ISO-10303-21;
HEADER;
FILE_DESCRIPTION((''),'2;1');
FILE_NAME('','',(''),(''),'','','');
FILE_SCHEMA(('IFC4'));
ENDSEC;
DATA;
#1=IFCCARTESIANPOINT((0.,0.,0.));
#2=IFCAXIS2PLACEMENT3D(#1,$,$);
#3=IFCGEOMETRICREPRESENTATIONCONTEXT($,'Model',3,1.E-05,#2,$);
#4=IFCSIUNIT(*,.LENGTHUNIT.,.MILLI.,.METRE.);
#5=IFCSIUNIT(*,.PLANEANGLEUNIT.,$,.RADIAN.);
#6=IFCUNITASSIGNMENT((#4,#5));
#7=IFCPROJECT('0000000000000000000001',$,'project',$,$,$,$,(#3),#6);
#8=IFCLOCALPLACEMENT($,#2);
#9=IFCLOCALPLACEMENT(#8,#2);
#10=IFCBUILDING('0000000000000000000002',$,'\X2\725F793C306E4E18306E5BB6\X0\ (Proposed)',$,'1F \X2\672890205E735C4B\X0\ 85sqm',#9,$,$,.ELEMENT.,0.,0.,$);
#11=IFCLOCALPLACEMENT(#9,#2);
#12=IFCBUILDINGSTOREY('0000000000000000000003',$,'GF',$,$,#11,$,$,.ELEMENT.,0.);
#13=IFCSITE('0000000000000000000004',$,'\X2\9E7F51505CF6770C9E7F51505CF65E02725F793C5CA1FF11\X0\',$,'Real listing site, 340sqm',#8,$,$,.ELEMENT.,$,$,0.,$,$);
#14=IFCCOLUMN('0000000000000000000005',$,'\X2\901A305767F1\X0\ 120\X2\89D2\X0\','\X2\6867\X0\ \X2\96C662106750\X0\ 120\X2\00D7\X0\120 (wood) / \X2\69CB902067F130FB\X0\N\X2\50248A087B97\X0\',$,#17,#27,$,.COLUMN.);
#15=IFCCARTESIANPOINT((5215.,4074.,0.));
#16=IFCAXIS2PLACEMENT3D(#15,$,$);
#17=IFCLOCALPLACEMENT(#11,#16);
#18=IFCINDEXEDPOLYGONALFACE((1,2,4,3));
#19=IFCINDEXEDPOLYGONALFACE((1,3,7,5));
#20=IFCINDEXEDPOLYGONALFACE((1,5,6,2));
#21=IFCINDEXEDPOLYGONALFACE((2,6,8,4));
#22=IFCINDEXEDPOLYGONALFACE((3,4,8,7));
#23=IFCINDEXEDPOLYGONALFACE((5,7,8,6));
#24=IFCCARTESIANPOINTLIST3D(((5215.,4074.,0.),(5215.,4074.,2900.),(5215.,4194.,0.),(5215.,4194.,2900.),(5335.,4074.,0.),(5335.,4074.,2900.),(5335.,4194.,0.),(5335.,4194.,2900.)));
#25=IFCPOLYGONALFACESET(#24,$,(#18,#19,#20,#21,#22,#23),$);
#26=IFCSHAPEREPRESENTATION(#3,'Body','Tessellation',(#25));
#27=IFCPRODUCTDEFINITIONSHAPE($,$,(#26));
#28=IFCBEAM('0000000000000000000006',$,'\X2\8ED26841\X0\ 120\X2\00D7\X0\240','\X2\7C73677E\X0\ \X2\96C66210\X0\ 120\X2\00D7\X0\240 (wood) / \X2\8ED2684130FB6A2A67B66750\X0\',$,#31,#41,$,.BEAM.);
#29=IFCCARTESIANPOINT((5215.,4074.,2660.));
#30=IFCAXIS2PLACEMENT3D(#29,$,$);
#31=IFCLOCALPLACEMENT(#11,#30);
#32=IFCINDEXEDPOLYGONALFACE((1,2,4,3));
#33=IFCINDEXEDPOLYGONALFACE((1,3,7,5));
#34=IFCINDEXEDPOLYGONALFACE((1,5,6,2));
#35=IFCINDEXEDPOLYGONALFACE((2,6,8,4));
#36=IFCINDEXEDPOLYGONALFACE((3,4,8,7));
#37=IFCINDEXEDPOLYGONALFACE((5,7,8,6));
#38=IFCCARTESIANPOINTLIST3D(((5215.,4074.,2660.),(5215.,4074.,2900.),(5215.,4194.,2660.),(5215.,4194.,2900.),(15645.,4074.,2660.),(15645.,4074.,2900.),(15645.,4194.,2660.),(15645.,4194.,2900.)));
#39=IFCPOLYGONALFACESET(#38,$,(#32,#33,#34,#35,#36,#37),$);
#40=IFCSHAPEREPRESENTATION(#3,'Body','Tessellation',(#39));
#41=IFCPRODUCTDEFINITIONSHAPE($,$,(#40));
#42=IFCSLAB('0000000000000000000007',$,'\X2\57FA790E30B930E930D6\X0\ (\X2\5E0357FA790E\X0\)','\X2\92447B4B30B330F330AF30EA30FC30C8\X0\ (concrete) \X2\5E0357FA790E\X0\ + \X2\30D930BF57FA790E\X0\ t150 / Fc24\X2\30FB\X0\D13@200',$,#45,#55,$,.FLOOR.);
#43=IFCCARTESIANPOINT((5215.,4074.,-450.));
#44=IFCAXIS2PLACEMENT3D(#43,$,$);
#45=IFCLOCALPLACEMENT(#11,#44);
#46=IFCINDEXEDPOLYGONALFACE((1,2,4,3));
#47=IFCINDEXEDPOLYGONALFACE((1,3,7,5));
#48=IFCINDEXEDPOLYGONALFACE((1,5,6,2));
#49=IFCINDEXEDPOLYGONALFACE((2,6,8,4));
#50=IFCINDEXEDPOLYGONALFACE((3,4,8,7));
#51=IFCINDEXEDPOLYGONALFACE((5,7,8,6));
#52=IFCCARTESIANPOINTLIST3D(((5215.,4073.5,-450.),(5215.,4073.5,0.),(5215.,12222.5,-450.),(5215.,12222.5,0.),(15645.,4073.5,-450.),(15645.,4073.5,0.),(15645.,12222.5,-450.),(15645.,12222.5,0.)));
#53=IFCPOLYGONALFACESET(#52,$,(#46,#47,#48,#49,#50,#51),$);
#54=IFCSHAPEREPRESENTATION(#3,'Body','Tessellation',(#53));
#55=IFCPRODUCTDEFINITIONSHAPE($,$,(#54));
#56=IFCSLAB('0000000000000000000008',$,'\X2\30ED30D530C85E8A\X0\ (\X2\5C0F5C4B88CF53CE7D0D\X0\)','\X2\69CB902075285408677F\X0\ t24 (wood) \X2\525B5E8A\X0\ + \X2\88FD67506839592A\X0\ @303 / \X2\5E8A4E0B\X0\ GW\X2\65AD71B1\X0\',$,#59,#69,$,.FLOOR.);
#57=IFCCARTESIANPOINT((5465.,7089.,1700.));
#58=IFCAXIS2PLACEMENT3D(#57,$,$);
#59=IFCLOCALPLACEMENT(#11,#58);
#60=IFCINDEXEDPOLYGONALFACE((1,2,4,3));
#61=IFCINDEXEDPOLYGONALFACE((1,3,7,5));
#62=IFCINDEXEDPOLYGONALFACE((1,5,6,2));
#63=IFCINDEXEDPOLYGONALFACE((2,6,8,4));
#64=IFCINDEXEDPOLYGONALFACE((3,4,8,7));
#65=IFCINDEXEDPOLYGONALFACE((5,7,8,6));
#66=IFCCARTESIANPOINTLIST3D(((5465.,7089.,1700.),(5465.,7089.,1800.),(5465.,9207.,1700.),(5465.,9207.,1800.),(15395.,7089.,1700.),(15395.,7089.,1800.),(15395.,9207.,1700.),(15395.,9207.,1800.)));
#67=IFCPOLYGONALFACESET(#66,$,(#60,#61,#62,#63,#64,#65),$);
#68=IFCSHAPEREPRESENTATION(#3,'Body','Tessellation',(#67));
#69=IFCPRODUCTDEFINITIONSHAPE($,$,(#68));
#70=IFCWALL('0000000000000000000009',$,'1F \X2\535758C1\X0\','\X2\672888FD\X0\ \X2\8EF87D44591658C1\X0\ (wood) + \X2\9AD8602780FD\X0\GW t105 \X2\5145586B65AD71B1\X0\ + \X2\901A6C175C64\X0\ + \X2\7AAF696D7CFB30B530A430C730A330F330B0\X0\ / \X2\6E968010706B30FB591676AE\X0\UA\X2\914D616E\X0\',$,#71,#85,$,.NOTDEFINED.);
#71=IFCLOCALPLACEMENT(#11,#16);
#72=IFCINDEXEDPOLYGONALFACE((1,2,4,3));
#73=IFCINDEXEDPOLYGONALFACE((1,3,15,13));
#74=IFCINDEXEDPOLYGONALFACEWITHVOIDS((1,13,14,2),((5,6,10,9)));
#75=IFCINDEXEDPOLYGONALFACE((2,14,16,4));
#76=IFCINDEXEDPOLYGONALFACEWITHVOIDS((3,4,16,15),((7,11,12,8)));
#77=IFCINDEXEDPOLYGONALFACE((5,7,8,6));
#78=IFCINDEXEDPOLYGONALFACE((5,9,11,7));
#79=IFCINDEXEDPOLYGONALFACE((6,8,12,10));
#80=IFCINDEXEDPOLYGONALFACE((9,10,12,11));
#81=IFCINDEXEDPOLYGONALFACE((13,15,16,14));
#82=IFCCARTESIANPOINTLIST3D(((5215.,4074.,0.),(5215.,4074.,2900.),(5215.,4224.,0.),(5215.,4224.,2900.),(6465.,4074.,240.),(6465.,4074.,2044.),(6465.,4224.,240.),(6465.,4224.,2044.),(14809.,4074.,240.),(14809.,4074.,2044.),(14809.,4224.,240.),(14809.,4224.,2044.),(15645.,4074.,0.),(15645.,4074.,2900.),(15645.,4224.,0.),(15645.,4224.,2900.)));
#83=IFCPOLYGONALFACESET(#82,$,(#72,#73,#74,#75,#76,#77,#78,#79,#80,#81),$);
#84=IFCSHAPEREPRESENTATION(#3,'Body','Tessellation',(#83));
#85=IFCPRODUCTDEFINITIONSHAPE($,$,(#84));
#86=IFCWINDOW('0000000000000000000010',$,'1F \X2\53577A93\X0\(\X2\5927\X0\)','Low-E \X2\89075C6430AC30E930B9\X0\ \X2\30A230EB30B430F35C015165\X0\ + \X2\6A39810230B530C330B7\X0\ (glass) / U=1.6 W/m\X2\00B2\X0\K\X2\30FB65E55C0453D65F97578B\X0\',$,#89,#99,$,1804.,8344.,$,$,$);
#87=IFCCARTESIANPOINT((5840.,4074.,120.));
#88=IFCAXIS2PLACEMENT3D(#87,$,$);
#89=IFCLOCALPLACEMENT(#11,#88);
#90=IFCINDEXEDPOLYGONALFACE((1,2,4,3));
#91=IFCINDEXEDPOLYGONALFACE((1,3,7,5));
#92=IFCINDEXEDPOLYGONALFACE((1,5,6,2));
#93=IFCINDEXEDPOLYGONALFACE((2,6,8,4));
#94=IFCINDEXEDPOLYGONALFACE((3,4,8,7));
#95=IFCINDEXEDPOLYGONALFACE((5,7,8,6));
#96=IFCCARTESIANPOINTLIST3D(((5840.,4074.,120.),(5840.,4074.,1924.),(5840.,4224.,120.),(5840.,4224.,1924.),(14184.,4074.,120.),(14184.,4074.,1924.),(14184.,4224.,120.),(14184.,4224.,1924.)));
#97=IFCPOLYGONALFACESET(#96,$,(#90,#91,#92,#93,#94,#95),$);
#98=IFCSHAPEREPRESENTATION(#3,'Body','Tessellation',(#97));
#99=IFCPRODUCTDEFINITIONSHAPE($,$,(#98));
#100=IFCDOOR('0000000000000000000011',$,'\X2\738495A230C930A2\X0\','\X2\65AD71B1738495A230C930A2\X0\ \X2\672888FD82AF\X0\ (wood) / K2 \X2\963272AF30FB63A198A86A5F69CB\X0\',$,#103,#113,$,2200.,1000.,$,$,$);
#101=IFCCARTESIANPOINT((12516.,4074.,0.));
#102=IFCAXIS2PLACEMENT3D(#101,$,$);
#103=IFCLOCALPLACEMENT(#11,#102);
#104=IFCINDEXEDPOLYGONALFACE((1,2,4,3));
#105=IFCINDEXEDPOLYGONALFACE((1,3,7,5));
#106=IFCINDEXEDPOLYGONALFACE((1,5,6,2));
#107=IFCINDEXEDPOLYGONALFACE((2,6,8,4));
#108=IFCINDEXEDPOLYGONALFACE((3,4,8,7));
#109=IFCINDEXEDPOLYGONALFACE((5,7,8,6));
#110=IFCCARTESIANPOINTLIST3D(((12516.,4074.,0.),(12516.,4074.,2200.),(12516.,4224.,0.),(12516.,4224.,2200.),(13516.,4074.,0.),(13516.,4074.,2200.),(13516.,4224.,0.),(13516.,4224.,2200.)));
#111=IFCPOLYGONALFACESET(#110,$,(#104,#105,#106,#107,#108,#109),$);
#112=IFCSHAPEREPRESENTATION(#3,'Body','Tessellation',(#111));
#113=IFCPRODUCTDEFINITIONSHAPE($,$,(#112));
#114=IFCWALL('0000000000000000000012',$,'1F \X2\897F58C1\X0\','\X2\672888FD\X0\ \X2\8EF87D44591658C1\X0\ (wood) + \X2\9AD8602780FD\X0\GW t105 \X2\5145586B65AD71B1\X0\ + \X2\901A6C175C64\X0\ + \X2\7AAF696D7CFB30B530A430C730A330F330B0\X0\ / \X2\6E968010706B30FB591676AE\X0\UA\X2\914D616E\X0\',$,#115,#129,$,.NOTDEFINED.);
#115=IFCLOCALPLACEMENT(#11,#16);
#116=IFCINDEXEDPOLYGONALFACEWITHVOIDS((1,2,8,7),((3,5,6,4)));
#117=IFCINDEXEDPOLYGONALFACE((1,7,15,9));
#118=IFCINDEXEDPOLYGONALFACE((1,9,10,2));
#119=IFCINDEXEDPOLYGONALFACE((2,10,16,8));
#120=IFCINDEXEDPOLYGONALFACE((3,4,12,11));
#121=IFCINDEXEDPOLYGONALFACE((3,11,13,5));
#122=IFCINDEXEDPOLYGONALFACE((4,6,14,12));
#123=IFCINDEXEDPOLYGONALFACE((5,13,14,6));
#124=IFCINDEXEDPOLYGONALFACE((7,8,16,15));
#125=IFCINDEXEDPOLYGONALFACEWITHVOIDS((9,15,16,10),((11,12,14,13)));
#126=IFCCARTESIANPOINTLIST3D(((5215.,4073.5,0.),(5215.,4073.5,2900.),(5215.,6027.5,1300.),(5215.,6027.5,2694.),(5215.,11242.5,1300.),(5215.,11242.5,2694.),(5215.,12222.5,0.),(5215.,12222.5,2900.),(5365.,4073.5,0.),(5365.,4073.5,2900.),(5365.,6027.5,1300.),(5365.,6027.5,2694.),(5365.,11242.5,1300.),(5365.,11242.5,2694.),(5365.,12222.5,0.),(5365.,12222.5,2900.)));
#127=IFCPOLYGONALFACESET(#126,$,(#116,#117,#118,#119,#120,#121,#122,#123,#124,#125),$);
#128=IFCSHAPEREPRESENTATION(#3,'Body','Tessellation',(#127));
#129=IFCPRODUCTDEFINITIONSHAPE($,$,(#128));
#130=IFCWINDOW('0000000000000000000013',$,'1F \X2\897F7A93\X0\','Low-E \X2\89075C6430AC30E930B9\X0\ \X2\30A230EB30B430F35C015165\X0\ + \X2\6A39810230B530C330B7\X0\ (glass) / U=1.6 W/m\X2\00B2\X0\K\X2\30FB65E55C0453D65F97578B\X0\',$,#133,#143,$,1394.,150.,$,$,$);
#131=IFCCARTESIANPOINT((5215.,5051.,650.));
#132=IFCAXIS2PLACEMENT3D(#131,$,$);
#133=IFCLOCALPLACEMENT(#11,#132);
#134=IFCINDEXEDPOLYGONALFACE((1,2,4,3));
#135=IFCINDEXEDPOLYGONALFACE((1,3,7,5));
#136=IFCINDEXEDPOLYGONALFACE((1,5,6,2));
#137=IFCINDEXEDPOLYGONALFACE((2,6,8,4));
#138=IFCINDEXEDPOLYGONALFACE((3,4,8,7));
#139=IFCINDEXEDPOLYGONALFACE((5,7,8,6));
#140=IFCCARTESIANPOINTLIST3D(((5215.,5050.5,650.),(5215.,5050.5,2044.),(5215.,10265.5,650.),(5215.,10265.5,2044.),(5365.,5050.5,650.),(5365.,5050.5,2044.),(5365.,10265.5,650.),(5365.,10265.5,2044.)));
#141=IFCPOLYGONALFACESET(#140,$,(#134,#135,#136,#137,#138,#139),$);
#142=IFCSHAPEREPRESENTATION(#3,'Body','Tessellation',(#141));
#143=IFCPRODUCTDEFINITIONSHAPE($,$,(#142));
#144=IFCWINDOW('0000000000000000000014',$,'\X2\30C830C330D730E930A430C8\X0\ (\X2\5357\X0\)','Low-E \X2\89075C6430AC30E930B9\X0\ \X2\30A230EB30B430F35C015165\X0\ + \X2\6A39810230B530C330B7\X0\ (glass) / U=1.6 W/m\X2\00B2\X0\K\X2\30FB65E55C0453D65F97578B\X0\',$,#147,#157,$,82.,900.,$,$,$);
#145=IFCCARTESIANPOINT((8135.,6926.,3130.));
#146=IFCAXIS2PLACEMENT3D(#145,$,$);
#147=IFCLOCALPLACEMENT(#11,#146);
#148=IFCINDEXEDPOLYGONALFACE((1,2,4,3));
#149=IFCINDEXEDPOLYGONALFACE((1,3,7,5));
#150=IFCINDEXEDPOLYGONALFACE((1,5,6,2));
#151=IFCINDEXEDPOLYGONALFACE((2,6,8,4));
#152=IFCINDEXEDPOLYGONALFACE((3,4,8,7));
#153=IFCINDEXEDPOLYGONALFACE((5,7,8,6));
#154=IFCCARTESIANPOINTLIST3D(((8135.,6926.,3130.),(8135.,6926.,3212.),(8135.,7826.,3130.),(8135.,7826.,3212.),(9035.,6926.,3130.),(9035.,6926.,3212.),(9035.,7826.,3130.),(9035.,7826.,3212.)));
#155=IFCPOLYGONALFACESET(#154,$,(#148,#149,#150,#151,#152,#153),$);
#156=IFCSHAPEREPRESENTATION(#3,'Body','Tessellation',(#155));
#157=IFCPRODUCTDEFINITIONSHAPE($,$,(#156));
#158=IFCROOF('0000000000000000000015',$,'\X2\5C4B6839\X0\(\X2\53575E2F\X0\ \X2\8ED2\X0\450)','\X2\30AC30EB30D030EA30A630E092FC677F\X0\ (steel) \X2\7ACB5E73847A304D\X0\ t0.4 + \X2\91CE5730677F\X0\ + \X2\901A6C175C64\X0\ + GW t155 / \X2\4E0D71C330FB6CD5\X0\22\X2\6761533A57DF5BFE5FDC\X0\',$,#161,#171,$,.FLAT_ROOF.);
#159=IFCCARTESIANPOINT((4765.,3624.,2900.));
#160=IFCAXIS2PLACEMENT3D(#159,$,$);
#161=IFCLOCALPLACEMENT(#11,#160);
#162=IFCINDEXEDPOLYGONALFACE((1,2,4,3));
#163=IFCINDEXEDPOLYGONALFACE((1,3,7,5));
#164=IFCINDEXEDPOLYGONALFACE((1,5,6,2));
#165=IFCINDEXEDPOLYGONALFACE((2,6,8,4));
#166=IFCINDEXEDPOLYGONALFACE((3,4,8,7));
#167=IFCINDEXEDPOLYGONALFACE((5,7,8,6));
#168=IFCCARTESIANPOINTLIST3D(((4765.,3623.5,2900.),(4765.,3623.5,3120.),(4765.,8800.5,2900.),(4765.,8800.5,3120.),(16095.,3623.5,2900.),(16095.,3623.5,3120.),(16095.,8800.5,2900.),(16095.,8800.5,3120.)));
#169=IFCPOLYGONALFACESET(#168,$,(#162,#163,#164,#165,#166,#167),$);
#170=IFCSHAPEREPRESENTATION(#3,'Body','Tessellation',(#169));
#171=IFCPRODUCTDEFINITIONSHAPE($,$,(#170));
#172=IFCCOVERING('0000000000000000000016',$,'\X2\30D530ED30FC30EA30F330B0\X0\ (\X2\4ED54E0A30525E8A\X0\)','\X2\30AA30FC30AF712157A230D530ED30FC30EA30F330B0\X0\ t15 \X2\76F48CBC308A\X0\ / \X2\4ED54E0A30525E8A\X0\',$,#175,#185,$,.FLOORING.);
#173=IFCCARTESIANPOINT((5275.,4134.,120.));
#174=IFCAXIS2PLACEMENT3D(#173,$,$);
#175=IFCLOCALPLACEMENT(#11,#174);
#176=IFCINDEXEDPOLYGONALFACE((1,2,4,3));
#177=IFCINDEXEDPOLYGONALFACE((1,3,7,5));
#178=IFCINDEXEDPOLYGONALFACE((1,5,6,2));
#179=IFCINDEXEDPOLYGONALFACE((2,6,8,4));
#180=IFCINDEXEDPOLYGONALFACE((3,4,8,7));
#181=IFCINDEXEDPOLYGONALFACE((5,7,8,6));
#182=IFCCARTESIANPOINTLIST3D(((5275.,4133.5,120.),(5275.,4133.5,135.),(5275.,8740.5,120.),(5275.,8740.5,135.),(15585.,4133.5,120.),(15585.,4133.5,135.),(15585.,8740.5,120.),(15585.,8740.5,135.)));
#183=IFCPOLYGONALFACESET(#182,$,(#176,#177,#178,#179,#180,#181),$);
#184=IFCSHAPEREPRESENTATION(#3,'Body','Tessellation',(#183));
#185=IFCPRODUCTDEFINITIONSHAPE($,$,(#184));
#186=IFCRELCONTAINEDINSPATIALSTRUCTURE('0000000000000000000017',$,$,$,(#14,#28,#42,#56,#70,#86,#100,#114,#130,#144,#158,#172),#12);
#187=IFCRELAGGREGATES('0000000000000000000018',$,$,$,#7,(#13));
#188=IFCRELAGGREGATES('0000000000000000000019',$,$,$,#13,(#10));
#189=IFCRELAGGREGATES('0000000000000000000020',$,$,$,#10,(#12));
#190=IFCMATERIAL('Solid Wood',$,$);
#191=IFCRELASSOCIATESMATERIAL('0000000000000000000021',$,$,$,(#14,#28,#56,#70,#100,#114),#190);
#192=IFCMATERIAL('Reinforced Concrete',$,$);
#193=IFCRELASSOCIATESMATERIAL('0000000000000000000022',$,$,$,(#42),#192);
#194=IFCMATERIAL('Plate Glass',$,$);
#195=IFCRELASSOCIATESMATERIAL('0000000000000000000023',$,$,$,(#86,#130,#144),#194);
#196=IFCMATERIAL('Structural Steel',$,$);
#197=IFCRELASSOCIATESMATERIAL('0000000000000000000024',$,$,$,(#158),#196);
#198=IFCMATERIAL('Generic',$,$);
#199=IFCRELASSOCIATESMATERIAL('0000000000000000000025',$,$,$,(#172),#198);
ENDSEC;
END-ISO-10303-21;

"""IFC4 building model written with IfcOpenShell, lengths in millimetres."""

from ifc_helpers import new_model, si_unit, frame, frame_2d, origin, place, context, project, spatial, rectangle, extrude, material, element, fill, save


model = new_model("IFC4")

# Units and contexts
model_context = context("Model", 3, precision=1e-05, world=origin())
ifc_project = project(units=[si_unit("LENGTHUNIT", "METRE", prefix="MILLI"), si_unit("PLANEANGLEUNIT", "RADIAN")], contexts=[model_context])

# Site, building, storey
site_placement = place(None, origin())
site = spatial("IfcSite", under=ifc_project, at=site_placement, Name="鹿児島県鹿児島市牟礼岡１", ObjectType="Real listing site, 340sqm", CompositionType="ELEMENT", RefElevation=0.0)
building_placement = place(site_placement, origin())
building = spatial("IfcBuilding", under=site, at=building_placement, Name="牟礼の丘の家 (Proposed)", ObjectType="1F 木造平屋 85sqm", CompositionType="ELEMENT", ElevationOfRefHeight=0.0, ElevationOfTerrain=0.0)
storey_placement = place(building_placement, origin())
storey = spatial("IfcBuildingStorey", under=building, at=storey_placement, Name="GF", CompositionType="ELEMENT", Elevation=0.0)

# Column
ifc_material_1 = material(Name="Solid Wood")
column_1_placement = place(storey_placement, frame((5215.0, 4074.0, 0.0)))
element("IfcColumn", 1, at=column_1_placement, inside=storey, material=ifc_material_1, Name="通し柱 120角", Description="桧 集成材 120×120 (wood) / 構造柱・N値計算", PredefinedType="COLUMN", context=model_context, shape_type="SweptSolid", body=[
    extrude(rectangle(XDim=120.0, YDim=120.0, at=frame_2d((60.0, 60.0))), frame((5215.0, 4074.0, 0.0)), (0.0, 0.0, 1.0), 2900.0),
])

# Beam
beam_1_placement = place(storey_placement, frame((5215.0, 4074.0, 2660.0)))
element("IfcBeam", 2, at=beam_1_placement, inside=storey, material=ifc_material_1, Name="軒桁 120×240", Description="米松 集成 120×240 (wood) / 軒桁・横架材", PredefinedType="BEAM", context=model_context, shape_type="SweptSolid", body=[
    extrude(rectangle(XDim=10430.0, YDim=120.0, at=frame_2d((5215.0, 60.0))), frame((5215.0, 4074.0, 2660.0)), (0.0, 0.0, 1.0), 240.0),
])

# Slabs
ifc_material_2 = material(Name="Reinforced Concrete")
slab_1_placement = place(storey_placement, frame((5215.0, 4074.0, -450.0)))
element("IfcSlab", 3, at=slab_1_placement, inside=storey, material=ifc_material_2, Name="基礎スラブ (布基礎)", Description="鉄筋コンクリート (concrete) 布基礎 + ベタ基礎 t150 / Fc24・D13@200", PredefinedType="FLOOR", context=model_context, shape_type="SweptSolid", body=[
    extrude(rectangle(XDim=10430.0, YDim=8149.0, at=frame_2d((5215.0, 4074.0))), frame((5215.0, 4074.0, -450.0)), (0.0, 0.0, 1.0), 450.0),
])
slab_2_placement = place(storey_placement, frame((5465.0, 7089.0, 1700.0)))
element("IfcSlab", 4, at=slab_2_placement, inside=storey, material=ifc_material_1, Name="ロフト床 (小屋裏収納)", Description="構造用合板 t24 (wood) 剛床 + 製材根太 @303 / 床下 GW断熱", PredefinedType="FLOOR", context=model_context, shape_type="SweptSolid", body=[
    extrude(rectangle(XDim=9930.0, YDim=2118.0, at=frame_2d((4965.0, 1059.0))), frame((5465.0, 7089.0, 1700.0)), (0.0, 0.0, 1.0), 100.0),
])

# Wall, openings, window, door
wall_1_placement = place(storey_placement, frame((5215.0, 4074.0, 0.0)))
wall_1 = element("IfcWall", 5, at=wall_1_placement, inside=storey, material=ifc_material_1, Name="1F 南壁", Description="木製 軸組外壁 (wood) + 高性能GW t105 充填断熱 + 通気層 + 窯業系サイディング / 準耐火・外皮UA配慮", PredefinedType="NOTDEFINED", context=model_context, shape_type="SweptSolid", body=[
    extrude(rectangle(XDim=10430.0, YDim=150.0, at=frame_2d((5215.0, 75.0))), frame((5215.0, 4074.0, 0.0)), (0.0, 0.0, 1.0), 2900.0),
])
opening_1_placement = place(storey_placement, frame((5840.0, 4074.0, 120.0)))
opening_1 = element("IfcOpeningElement", 6, at=opening_1_placement, cuts=wall_1, PredefinedType="NOTDEFINED", context=model_context, shape_type="SweptSolid", body=[
    extrude(rectangle(XDim=8344.0, YDim=150.0, at=frame_2d((4172.0, 75.0))), frame((5840.0, 4074.0, 120.0)), (0.0, 0.0, 1.0), 1804.0),
])
opening_2_placement = place(storey_placement, frame((12516.0, 4074.0, 0.0)))
opening_2 = element("IfcOpeningElement", 7, at=opening_2_placement, cuts=wall_1, PredefinedType="NOTDEFINED", context=model_context, shape_type="SweptSolid", body=[
    extrude(rectangle(XDim=1000.0, YDim=150.0, at=frame_2d((500.0, 75.0))), frame((12516.0, 4074.0, 0.0)), (0.0, 0.0, 1.0), 2200.0),
])
ifc_material_3 = material(Name="Plate Glass")
window_1_placement = place(storey_placement, frame((5840.0, 4074.0, 120.0)))
window_1 = element("IfcWindow", 8, at=window_1_placement, inside=storey, material=ifc_material_3, Name="1F 南窓(大)", Description="Low-E 複層ガラス アルゴン封入 + 樹脂サッシ (glass) / U=1.6 W/m²K・日射取得型", OverallHeight=1804.0, OverallWidth=8344.0, context=model_context, shape_type="SweptSolid", body=[
    extrude(rectangle(XDim=8344.0, YDim=150.0, at=frame_2d((4172.0, 75.0))), frame((5840.0, 4074.0, 120.0)), (0.0, 0.0, 1.0), 1804.0),
])
fill(opening_1, window_1)
door_placement = place(storey_placement, frame((12516.0, 4074.0, 0.0)))
door = element("IfcDoor", 9, at=door_placement, inside=storey, material=ifc_material_1, Name="玄関ドア", Description="断熱玄関ドア 木製芯 (wood) / K2 防犯・採風機構", OverallHeight=2200.0, OverallWidth=1000.0, context=model_context, shape_type="SweptSolid", body=[
    extrude(rectangle(XDim=1000.0, YDim=150.0, at=frame_2d((500.0, 75.0))), frame((12516.0, 4074.0, 0.0)), (0.0, 0.0, 1.0), 2200.0),
])
fill(opening_2, door)

# Wall, opening, window
wall_2_placement = place(storey_placement, frame((5215.0, 4074.0, 0.0)))
wall_2 = element("IfcWall", 10, at=wall_2_placement, inside=storey, material=ifc_material_1, Name="1F 西壁", Description="木製 軸組外壁 (wood) + 高性能GW t105 充填断熱 + 通気層 + 窯業系サイディング / 準耐火・外皮UA配慮", PredefinedType="NOTDEFINED", context=model_context, shape_type="SweptSolid", body=[
    extrude(rectangle(XDim=150.0, YDim=8149.0, at=frame_2d((75.0, 4074.0))), frame((5215.0, 4074.0, 0.0)), (0.0, 0.0, 1.0), 2900.0),
])
opening_3_placement = place(storey_placement, frame((5215.0, 5051.0, 650.0)))
opening_3 = element("IfcOpeningElement", 11, at=opening_3_placement, cuts=wall_2, PredefinedType="NOTDEFINED", context=model_context, shape_type="SweptSolid", body=[
    extrude(rectangle(XDim=150.0, YDim=5215.0, at=frame_2d((75.0, 2607.0))), frame((5215.0, 5051.0, 650.0)), (0.0, 0.0, 1.0), 1394.0),
])
window_2_placement = place(storey_placement, frame((5215.0, 5051.0, 650.0)))
window_2 = element("IfcWindow", 12, at=window_2_placement, inside=storey, material=ifc_material_3, Name="1F 西窓", Description="Low-E 複層ガラス アルゴン封入 + 樹脂サッシ (glass) / U=1.6 W/m²K・日射取得型", OverallHeight=1394.0, OverallWidth=150.0, context=model_context, shape_type="SweptSolid", body=[
    extrude(rectangle(XDim=150.0, YDim=5215.0, at=frame_2d((75.0, 2607.0))), frame((5215.0, 5051.0, 650.0)), (0.0, 0.0, 1.0), 1394.0),
])
fill(opening_3, window_2)

# Window
window_3_placement = place(storey_placement, frame((8135.0, 6926.0, 3130.0)))
element("IfcWindow", 13, at=window_3_placement, inside=storey, material=ifc_material_3, Name="トップライト (南)", Description="Low-E 複層ガラス アルゴン封入 + 樹脂サッシ (glass) / U=1.6 W/m²K・日射取得型", OverallHeight=82.0, OverallWidth=900.0, context=model_context, shape_type="SweptSolid", body=[
    extrude(rectangle(XDim=900.0, YDim=900.0, at=frame_2d((450.0, 450.0))), frame((8135.0, 6926.0, 3130.0)), (0.0, 0.0, 1.0), 82.0),
])

# Roof
ifc_material_4 = material(Name="Structural Steel")
roof_placement = place(storey_placement, frame((4765.0, 3624.0, 2900.0)))
element("IfcRoof", 14, at=roof_placement, inside=storey, material=ifc_material_4, Name="屋根(南帯 軒450)", Description="ガルバリウム鋼板 (steel) 立平葺き t0.4 + 野地板 + 通気層 + GW t155 / 不燃・法22条区域対応", PredefinedType="FLAT_ROOF", context=model_context, shape_type="SweptSolid", body=[
    extrude(rectangle(XDim=11330.0, YDim=5177.0, at=frame_2d((5665.0, 2588.0))), frame((4765.0, 3624.0, 2900.0)), (0.0, 0.0, 1.0), 220.0),
])

# Covering
ifc_material_5 = material(Name="Generic")
covering_1_placement = place(storey_placement, frame((5275.0, 4134.0, 120.0)))
element("IfcCovering", 15, at=covering_1_placement, inside=storey, material=ifc_material_5, Name="フローリング (仕上げ床)", Description="オーク無垢フローリング t15 直貼り / 仕上げ床", PredefinedType="FLOORING", context=model_context, shape_type="SweptSolid", body=[
    extrude(rectangle(XDim=10310.0, YDim=4607.0, at=frame_2d((5155.0, 2303.0))), frame((5275.0, 4134.0, 120.0)), (0.0, 0.0, 1.0), 15.0),
])

save(model, "model.ifc")
